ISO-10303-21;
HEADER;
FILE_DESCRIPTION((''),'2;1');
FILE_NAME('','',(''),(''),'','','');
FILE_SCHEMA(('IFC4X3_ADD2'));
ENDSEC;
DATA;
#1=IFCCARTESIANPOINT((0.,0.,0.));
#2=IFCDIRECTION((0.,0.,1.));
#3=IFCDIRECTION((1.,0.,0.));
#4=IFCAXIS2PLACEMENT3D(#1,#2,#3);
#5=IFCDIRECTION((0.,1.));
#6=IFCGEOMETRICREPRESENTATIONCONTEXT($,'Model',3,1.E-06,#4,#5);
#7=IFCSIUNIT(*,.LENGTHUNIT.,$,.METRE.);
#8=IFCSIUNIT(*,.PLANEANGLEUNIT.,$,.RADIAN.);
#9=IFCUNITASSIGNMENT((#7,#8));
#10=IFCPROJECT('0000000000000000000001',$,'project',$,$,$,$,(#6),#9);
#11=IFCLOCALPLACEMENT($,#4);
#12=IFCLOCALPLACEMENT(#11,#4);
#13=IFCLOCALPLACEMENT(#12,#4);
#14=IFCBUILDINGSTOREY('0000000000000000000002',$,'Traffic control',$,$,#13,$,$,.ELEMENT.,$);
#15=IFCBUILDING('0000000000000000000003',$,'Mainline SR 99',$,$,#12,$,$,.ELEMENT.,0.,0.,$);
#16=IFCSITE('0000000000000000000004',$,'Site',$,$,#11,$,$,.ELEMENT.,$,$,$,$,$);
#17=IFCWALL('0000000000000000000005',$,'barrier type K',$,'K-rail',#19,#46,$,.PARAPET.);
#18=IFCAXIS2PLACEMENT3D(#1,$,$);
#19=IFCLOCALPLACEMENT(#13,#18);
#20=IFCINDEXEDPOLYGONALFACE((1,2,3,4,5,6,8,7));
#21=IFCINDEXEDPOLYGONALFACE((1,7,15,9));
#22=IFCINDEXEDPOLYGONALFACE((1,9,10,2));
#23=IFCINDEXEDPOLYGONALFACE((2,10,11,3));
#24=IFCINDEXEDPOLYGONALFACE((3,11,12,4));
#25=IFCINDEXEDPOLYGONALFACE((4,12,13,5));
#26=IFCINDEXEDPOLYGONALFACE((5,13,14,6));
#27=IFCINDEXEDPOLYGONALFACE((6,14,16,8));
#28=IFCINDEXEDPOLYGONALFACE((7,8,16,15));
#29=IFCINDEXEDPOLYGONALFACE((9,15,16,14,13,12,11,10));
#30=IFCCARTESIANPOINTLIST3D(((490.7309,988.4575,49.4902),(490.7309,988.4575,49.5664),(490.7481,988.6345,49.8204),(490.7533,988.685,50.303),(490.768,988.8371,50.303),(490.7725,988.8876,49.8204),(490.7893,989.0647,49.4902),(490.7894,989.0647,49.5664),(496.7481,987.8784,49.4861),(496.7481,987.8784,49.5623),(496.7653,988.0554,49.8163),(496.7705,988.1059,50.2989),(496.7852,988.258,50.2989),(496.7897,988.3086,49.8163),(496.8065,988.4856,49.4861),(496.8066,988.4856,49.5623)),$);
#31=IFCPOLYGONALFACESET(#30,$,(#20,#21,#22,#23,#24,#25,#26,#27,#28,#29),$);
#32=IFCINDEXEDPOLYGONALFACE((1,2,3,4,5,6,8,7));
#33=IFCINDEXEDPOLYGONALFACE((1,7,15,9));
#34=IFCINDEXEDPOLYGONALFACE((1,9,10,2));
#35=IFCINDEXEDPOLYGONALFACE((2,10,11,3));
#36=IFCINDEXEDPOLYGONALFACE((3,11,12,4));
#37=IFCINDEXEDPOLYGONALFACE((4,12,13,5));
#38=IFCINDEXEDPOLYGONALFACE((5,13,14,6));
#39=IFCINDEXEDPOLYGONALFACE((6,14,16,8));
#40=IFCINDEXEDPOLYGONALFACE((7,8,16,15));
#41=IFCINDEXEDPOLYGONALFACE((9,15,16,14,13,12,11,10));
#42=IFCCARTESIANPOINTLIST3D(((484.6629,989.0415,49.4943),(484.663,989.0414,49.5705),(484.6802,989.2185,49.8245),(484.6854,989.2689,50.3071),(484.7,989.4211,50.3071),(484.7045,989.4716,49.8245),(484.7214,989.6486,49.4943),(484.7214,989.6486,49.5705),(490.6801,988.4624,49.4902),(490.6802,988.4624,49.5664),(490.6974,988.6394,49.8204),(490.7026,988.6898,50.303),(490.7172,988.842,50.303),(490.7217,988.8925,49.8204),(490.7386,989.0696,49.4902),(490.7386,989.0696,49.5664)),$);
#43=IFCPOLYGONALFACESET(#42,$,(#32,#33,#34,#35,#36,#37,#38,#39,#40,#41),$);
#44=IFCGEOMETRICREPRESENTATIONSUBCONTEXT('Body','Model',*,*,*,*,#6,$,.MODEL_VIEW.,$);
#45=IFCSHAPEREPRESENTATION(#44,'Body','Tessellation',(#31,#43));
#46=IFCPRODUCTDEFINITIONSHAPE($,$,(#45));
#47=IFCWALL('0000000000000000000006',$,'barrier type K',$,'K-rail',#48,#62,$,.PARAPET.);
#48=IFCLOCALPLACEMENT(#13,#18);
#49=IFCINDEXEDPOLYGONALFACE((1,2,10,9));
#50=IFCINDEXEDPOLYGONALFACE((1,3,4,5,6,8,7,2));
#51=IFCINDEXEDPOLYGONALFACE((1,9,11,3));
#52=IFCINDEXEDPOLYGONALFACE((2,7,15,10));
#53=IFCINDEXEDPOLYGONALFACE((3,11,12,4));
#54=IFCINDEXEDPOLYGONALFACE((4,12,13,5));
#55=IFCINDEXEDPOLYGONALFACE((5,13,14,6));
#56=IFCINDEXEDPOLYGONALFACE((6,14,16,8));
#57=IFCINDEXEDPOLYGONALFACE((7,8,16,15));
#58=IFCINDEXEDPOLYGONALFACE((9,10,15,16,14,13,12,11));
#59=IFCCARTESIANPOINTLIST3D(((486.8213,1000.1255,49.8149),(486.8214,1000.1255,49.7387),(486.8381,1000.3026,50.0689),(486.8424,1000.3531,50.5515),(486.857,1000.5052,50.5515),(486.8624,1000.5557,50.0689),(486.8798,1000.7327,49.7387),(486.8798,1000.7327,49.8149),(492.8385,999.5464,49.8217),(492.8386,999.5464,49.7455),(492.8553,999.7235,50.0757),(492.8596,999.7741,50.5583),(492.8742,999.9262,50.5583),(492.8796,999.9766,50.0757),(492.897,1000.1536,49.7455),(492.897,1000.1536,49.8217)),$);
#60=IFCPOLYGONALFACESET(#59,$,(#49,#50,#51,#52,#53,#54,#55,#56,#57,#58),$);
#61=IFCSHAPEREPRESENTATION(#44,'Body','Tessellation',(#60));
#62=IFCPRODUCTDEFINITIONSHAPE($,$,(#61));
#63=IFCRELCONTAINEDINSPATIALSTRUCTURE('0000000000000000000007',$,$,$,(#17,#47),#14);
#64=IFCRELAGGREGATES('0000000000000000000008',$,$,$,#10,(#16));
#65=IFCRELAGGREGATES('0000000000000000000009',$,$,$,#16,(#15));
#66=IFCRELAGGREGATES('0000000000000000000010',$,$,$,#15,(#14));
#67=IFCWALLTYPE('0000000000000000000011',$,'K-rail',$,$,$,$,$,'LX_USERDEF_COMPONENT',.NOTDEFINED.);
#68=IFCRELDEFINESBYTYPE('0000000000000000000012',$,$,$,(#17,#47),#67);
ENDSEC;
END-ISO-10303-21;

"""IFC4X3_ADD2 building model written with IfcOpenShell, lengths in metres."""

from ifc_helpers import new_model, si_unit, direction, frame, origin_with_axes, place, context, subcontext, project, spatial, polyline, outline, extrude, source, transform, mapped, type_object, element, save


model = new_model("IFC4X3_ADD2")

# Units and contexts
model_context = context("Model", 3, precision=1e-06, world=origin_with_axes(), true_north=direction((0.0, 1.0)))
body_context = subcontext(model_context, "Body", "Model", "MODEL_VIEW")
ifc_project = project(units=[si_unit("LENGTHUNIT", "METRE"), si_unit("PLANEANGLEUNIT", "RADIAN")], contexts=[model_context])

# Site, building, storey
site_placement = place(None, origin_with_axes())
site = spatial("IfcSite", under=ifc_project, at=site_placement, Name="Site", CompositionType="ELEMENT")
building_placement = place(site_placement, origin_with_axes())
building = spatial("IfcBuilding", under=site, at=building_placement, Name="Mainline SR 99", CompositionType="ELEMENT", ElevationOfRefHeight=0.0, ElevationOfTerrain=0.0)
storey_placement = place(building_placement, origin_with_axes())
storey = spatial("IfcBuildingStorey", under=building, at=storey_placement, Name="Traffic control", CompositionType="ELEMENT")

# Walls
wall_type = type_object("IfcWallType", Name="K-rail", ElementType="LX_USERDEF_COMPONENT", PredefinedType="NOTDEFINED")
shared_shape_1 = source(origin_with_axes(), body_context, "Body", "SweptSolid", [
    extrude(outline(polyline([(0.305, 0.0), (0.305, 0.0762), (0.1271, 0.3302), (0.0764, 0.8128), (-0.0764, 0.8128), (-0.1271, 0.3302), (-0.305, 0.0762), (-0.305, 0.0), (0.305, 0.0)])), origin_with_axes(), (0.0, 0.0, 1.0), 6.045),
])
shared_shape_2 = source(origin_with_axes(), body_context, "Body", "SweptSolid", [
    extrude(outline(polyline([(0.305, 0.0), (0.305, 0.0762), (0.1271, 0.3302), (0.0764, 0.8128), (-0.0764, 0.8128), (-0.1271, 0.3302), (-0.305, 0.0762), (-0.305, 0.0), (0.305, 0.0)])), origin_with_axes(), (0.0, 0.0, 1.0), 6.045),
])
wall_1_placement = place(storey_placement, frame((1366.797, 551.712, -2.0), z_axis=(0.0, 0.0, 1.0), x_axis=(1.0, 0.0, 0.0)))
element("IfcWall", 1, at=wall_1_placement, inside=storey, type_object=wall_type, Name="barrier type K", ObjectType="K-rail", PredefinedType="PARAPET", context=body_context, shape_type="MappedRepresentation", body=[
    mapped(shared_shape_1, transform((-876.0369, 437.0491, 51.4902), x_axis=(0.095791, 0.995401, 0.0), y_axis=(0.00067, -0.000064, 1.0), z_axis=(0.995401, -0.095791, -0.000673), scale=1.0)),
    mapped(shared_shape_2, transform((-882.1049, 437.6331, 51.4943), x_axis=(0.095795, 0.995401, 0.0), y_axis=(0.000675, -0.000065, 1.0), z_axis=(0.995401, -0.095795, -0.000678), scale=1.0)),
])
wall_2_placement = place(storey_placement, frame((486.8506, 1000.4291, 49.7387), z_axis=(0.995401, -0.09579, 0.001117), x_axis=(0.09579, 0.995402, 0.0)))
element("IfcWall", 2, at=wall_2_placement, inside=storey, type_object=wall_type, Name="barrier type K", ObjectType="K-rail", PredefinedType="PARAPET", context=body_context, shape_type="SweptSolid", body=[
    extrude(outline(polyline([(0.305, 0.0), (0.305, 0.0762), (0.1271, 0.3302), (0.0764, 0.8128), (-0.0764, 0.8128), (-0.1271, 0.3302), (-0.305, 0.0762), (-0.305, 0.0), (0.305, 0.0)])), origin_with_axes(), (0.0, 0.0, 1.0), 6.045),
])

save(model, "model.ifc")
